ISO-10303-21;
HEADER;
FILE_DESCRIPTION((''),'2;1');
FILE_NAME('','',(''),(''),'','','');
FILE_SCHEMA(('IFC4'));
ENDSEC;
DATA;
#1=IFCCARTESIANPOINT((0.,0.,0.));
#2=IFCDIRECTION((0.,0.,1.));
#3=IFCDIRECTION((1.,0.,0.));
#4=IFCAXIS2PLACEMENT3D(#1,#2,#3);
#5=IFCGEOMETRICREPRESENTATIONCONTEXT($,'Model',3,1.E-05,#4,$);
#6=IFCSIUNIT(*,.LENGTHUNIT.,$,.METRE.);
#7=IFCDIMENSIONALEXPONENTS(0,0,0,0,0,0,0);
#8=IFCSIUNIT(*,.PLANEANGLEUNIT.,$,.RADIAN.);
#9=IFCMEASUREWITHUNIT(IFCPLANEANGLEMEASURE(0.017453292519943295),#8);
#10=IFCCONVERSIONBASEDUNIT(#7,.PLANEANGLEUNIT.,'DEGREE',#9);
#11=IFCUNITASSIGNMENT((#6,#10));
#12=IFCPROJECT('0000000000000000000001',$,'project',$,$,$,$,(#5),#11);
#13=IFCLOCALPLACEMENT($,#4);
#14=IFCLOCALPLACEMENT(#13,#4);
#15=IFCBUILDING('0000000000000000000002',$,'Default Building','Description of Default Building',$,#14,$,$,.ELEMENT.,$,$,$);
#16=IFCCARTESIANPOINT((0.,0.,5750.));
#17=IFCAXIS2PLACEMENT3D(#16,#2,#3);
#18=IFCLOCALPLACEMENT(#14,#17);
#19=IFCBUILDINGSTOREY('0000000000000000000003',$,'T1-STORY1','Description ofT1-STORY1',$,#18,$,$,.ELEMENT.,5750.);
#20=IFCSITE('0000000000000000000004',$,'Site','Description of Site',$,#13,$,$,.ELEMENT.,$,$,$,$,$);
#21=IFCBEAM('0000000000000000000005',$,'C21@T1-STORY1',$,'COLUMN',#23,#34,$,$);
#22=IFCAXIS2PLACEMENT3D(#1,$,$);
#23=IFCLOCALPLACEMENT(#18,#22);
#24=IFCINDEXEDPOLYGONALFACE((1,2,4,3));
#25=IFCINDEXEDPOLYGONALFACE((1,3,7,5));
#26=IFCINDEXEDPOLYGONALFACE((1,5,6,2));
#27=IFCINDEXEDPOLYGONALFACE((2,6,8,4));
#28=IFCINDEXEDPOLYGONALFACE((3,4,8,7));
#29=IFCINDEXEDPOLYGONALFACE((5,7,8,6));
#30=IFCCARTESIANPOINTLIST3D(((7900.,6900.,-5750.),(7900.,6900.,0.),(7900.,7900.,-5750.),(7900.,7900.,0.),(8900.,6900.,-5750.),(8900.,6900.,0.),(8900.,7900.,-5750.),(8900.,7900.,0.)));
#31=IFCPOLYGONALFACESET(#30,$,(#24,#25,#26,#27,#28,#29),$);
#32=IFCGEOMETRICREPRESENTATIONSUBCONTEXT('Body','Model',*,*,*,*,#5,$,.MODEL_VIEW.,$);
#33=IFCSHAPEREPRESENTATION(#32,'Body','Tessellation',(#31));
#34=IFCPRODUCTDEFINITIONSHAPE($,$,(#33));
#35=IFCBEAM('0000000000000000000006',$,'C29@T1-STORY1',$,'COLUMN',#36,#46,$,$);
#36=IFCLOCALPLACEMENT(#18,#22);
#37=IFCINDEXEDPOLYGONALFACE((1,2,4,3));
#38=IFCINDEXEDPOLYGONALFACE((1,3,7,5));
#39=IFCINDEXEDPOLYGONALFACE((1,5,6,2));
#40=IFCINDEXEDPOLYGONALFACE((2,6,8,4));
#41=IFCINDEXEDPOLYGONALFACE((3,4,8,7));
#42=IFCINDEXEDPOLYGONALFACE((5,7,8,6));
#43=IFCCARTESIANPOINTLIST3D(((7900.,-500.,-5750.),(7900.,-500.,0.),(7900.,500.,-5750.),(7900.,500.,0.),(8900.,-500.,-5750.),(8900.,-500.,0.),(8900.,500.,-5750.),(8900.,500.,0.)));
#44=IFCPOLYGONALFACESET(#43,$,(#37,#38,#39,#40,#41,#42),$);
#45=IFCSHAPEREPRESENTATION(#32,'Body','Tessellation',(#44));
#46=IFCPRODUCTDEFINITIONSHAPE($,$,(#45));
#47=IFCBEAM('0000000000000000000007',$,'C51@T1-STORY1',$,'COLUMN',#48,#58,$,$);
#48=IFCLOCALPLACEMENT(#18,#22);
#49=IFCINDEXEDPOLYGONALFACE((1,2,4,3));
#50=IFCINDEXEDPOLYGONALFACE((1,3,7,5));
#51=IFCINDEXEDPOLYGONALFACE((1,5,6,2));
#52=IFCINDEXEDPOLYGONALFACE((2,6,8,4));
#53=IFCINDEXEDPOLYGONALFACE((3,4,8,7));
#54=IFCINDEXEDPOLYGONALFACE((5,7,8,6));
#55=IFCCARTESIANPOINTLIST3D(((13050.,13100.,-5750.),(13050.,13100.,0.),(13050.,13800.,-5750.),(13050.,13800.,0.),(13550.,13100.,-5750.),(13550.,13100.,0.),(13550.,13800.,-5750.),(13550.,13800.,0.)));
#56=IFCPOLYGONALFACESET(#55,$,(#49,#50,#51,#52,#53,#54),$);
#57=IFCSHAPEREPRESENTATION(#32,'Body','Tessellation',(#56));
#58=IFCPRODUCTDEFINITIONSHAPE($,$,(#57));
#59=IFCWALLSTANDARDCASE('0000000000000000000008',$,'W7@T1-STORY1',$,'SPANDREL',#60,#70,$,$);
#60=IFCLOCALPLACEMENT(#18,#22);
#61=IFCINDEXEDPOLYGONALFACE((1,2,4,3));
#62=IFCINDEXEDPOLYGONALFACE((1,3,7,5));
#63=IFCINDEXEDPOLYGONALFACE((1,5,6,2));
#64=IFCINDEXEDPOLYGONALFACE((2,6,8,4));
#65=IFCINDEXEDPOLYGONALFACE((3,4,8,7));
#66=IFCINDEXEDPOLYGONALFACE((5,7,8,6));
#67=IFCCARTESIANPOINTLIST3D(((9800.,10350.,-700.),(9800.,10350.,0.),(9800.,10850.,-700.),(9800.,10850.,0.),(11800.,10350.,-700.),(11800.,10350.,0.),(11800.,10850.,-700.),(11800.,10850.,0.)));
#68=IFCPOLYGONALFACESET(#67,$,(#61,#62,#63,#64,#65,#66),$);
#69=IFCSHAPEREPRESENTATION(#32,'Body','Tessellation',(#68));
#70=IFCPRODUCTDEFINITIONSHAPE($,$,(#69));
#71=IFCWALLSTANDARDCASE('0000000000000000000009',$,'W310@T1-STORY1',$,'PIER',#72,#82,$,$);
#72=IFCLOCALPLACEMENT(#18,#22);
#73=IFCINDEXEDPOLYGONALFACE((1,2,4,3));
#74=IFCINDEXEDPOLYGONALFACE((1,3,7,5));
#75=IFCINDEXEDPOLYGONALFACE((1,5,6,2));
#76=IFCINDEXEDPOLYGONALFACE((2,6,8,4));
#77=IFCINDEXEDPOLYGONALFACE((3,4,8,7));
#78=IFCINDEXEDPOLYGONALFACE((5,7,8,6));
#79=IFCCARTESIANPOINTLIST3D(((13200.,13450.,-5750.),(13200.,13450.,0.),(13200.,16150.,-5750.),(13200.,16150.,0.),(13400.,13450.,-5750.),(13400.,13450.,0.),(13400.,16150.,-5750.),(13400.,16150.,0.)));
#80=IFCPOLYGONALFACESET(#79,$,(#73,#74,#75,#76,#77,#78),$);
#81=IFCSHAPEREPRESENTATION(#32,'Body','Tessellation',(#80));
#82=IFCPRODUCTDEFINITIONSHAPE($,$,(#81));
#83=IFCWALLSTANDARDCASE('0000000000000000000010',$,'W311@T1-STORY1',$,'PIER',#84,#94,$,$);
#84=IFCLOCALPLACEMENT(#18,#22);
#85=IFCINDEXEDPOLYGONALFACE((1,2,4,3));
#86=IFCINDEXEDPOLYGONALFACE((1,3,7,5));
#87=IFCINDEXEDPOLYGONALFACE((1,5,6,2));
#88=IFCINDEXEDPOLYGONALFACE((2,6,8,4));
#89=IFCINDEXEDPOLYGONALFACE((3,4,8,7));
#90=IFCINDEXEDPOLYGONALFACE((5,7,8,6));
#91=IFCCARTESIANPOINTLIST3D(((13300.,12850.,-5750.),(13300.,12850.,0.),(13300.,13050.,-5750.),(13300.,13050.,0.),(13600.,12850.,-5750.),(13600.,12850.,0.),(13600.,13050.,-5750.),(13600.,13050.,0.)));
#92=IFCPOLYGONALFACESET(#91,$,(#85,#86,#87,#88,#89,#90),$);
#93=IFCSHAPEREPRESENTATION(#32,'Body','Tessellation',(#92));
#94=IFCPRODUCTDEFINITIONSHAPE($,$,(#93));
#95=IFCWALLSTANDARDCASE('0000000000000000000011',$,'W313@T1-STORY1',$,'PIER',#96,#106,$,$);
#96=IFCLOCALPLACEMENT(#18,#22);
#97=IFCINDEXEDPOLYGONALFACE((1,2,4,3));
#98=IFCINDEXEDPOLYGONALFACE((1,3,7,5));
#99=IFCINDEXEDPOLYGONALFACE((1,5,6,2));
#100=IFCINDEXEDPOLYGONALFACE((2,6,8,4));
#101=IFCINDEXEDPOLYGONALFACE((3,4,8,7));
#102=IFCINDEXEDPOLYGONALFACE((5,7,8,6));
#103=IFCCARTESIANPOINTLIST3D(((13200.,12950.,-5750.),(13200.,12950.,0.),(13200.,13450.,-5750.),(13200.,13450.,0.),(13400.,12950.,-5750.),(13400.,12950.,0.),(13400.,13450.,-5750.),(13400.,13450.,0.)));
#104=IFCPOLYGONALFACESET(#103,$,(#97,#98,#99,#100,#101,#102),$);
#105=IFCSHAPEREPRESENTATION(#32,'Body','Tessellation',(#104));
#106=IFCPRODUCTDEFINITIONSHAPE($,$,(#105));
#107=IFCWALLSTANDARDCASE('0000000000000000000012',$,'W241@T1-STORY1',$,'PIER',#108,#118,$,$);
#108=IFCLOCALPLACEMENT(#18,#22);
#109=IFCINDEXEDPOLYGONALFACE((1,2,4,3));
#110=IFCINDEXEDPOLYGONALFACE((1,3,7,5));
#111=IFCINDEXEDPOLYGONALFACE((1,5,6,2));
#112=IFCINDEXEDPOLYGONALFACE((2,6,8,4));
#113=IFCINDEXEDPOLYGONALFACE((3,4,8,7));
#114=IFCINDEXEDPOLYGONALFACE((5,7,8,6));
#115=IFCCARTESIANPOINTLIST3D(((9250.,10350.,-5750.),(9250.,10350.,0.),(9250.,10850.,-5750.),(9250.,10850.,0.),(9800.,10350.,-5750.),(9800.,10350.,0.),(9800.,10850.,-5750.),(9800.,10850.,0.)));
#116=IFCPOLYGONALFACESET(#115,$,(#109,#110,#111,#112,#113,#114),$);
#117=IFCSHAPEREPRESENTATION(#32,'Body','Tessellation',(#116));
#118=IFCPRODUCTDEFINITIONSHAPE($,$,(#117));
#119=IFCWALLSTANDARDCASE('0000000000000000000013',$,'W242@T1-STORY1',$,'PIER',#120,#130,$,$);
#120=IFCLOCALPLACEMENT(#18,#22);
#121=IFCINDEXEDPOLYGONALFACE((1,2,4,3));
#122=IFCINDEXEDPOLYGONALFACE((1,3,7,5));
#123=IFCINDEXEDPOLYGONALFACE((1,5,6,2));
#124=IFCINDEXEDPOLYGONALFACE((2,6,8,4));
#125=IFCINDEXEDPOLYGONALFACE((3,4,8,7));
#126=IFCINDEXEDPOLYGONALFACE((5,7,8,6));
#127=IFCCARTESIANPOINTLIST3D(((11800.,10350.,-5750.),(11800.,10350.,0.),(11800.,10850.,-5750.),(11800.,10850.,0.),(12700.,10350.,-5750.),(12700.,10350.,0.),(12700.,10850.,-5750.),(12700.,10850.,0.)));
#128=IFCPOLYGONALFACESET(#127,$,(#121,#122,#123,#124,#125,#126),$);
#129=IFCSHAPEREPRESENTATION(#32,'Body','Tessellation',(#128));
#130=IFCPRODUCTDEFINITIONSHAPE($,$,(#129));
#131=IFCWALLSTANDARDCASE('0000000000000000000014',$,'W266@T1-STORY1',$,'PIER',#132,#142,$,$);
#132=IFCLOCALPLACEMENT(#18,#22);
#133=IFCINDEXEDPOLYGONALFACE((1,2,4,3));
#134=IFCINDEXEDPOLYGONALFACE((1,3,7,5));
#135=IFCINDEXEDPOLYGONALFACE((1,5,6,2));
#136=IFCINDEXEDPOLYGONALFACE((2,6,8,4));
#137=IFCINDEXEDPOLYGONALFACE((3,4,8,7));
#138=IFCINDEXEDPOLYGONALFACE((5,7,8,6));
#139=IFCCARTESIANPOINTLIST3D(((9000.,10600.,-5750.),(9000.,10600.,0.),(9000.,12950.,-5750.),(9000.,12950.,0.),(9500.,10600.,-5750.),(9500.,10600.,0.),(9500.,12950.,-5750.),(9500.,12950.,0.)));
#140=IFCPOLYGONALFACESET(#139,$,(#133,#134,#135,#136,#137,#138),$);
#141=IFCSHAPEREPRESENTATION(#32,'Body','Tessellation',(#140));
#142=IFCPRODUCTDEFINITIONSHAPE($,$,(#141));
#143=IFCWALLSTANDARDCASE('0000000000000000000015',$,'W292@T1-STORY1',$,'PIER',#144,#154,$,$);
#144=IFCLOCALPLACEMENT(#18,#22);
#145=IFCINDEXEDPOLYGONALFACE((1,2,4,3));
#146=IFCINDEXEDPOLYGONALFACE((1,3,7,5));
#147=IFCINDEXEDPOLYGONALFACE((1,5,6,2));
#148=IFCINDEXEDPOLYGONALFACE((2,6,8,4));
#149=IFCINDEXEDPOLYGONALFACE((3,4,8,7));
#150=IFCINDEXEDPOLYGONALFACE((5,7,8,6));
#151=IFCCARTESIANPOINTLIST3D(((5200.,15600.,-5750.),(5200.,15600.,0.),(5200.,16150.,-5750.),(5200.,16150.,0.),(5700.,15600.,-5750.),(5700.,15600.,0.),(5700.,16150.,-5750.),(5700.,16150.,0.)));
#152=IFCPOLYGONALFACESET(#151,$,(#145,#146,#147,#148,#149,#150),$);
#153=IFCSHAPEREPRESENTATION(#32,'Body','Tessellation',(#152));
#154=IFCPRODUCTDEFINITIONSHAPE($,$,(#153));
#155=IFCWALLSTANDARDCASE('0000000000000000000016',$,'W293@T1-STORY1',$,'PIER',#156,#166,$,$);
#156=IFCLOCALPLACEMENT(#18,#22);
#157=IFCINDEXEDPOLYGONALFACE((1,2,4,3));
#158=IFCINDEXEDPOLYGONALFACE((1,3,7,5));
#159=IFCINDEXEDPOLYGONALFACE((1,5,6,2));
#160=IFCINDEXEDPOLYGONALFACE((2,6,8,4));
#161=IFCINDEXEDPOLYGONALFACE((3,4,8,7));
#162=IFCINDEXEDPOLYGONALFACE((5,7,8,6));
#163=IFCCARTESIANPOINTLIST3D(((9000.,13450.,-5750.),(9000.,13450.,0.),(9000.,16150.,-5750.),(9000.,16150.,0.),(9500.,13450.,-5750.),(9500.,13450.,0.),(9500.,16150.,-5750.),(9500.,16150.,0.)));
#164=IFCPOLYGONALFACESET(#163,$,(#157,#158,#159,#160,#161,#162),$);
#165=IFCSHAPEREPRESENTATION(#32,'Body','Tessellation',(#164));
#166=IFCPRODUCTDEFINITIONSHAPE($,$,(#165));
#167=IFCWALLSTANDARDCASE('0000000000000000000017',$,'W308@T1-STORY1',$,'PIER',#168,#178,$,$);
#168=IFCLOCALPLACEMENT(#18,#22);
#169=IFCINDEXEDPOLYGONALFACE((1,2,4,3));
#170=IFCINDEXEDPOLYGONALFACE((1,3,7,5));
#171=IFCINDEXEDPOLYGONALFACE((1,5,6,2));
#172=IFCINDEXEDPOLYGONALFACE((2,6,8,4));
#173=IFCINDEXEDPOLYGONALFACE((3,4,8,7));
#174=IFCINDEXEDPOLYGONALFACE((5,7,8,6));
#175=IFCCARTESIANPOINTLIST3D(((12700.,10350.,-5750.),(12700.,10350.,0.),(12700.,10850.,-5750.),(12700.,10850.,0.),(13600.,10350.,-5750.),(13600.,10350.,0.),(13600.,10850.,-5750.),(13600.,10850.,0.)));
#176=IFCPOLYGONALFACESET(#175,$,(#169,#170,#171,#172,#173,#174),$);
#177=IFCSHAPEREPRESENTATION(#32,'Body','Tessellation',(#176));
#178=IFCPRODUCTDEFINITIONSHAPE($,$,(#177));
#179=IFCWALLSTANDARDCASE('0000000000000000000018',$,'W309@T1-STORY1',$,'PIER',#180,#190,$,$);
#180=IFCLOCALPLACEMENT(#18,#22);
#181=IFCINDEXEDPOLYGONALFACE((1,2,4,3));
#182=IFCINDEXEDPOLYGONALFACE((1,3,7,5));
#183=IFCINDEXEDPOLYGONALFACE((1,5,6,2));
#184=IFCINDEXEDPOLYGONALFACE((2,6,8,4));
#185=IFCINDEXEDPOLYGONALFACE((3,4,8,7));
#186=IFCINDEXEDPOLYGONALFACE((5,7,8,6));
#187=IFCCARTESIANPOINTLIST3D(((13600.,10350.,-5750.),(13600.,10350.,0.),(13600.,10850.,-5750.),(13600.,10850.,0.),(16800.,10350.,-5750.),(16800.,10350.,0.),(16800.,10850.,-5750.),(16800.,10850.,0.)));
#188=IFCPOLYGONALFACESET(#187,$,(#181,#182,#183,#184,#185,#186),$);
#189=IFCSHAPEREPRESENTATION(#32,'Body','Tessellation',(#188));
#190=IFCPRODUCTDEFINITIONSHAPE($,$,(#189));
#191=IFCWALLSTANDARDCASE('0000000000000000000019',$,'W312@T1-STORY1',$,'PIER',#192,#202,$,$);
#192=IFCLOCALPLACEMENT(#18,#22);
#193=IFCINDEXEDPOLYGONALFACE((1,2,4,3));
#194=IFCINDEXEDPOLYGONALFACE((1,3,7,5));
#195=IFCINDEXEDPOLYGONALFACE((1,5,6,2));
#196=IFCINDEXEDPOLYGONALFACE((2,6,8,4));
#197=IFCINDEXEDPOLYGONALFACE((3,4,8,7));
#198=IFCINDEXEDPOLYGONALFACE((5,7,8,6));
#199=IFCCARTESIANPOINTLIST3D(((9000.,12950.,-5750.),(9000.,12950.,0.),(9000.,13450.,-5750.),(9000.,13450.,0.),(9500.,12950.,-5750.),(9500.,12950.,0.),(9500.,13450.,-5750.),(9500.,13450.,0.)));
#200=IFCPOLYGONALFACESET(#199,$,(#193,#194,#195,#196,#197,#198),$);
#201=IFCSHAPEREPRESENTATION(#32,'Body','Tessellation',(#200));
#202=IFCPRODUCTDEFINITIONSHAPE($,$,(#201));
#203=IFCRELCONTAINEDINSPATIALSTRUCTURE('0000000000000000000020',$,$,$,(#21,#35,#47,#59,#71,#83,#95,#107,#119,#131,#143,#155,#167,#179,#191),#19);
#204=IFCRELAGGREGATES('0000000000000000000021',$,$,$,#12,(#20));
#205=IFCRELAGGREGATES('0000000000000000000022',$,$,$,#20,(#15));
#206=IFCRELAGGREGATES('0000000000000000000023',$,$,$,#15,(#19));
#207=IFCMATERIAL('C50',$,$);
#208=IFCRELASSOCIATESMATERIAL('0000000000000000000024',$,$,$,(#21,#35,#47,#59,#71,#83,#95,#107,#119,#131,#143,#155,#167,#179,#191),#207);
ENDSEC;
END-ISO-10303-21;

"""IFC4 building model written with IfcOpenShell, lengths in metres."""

from ifc_helpers import new_model, entity, si_unit, converted_unit, frame, origin_with_axes, place, context, subcontext, project, spatial, indexed_curve, rectangle, outline, extrude, material, element, save


model = new_model("IFC4")

# Units and contexts
model_context = context("Model", 3, precision=1e-05, world=origin_with_axes())
body_context = subcontext(model_context, "Body", "Model", "MODEL_VIEW")
ifc_project = project(units=[si_unit("LENGTHUNIT", "METRE"), converted_unit("PLANEANGLEUNIT", "DEGREE", entity("IfcPlaneAngleMeasure", 0.017453292519943295), si_unit("PLANEANGLEUNIT", "RADIAN"), dimensions=[0, 0, 0, 0, 0, 0, 0])], contexts=[model_context])

# Site, building, storey
site_placement = place(None, origin_with_axes())
site = spatial("IfcSite", under=ifc_project, at=site_placement, Name="Site", Description="Description of Site", CompositionType="ELEMENT")
building_placement = place(site_placement, origin_with_axes())
building = spatial("IfcBuilding", under=site, at=building_placement, Name="Default Building", Description="Description of Default Building", CompositionType="ELEMENT")
storey_placement = place(building_placement, frame((0.0, 0.0, 5750.0), z_axis=(0.0, 0.0, 1.0), x_axis=(1.0, 0.0, 0.0)))
storey = spatial("IfcBuildingStorey", under=building, at=storey_placement, Name="T1-STORY1", Description="Description ofT1-STORY1", CompositionType="ELEMENT", Elevation=5750.0)

# Beams
ifc_material_1 = material(Name="C50")
for number, where, z_axis, x_axis, name in (
    (1, (8400.0, 7400.0, -5750.0), (0.0, 0.0, 1.0), (-1.0, 0.0, 0.0), "C21@T1-STORY1"),
    (2, (8400.0, 0.0, -5750.0), (0.0, 0.0, 1.0), (-1.0, 0.0, 0.0), "C29@T1-STORY1"),
):
    element("IfcBeam", number, at=place(storey_placement, frame(where, z_axis=z_axis, x_axis=x_axis)), inside=storey, material=ifc_material_1, Name=name, ObjectType="COLUMN", context=body_context, shape_type="SweptSolid", body=[
        extrude(rectangle(XDim=1000.0, YDim=1000.0), origin_with_axes(), (0.0, 0.0, 1.0), 5750.0),
    ])
beam_1_placement = place(storey_placement, frame((13300.0, 13450.0, -5750.0), z_axis=(0.0, 0.0, 1.0), x_axis=(-1.0, 0.0, 0.0)))
element("IfcBeam", 3, at=beam_1_placement, inside=storey, material=ifc_material_1, Name="C51@T1-STORY1", ObjectType="COLUMN", context=body_context, shape_type="SweptSolid", body=[
    extrude(rectangle(XDim=500.0, YDim=700.0), origin_with_axes(), (0.0, 0.0, 1.0), 5750.0),
])

# Walls
wall_1_placement = place(storey_placement, frame((9800.0, 10600.0, -700.0), z_axis=(0.0, 0.0, 1.0), x_axis=(1.0, 0.0, 0.0)))
element("IfcWallStandardCase", 4, at=wall_1_placement, inside=storey, material=ifc_material_1, Name="W7@T1-STORY1", ObjectType="SPANDREL", context=body_context, shape_type="SweptSolid", body=[
    extrude(outline(indexed_curve([(0.0, -250.0), (0.0, 250.0), (2000.0, 250.0), (2000.0, -250.0), (0.0, -250.0)], self_intersect=False)), origin_with_axes(), (0.0, 0.0, 1.0), 700.0),
])
wall_2_placement = place(storey_placement, frame((13300.0, 13450.0, -5750.0), z_axis=(0.0, 0.0, 1.0), x_axis=(0.0, 1.0, 0.0)))
element("IfcWallStandardCase", 5, at=wall_2_placement, inside=storey, material=ifc_material_1, Name="W310@T1-STORY1", ObjectType="PIER", context=body_context, shape_type="SweptSolid", body=[
    extrude(outline(indexed_curve([(0.0, -100.0), (0.0, 100.0), (2700.0, 100.0), (2700.0, -100.0), (0.0, -100.0)], self_intersect=False)), origin_with_axes(), (0.0, 0.0, 1.0), 5750.0),
])
wall_3_placement = place(storey_placement, frame((13300.0, 12950.0, -5750.0), z_axis=(0.0, 0.0, 1.0), x_axis=(1.0, 0.0, 0.0)))
element("IfcWallStandardCase", 6, at=wall_3_placement, inside=storey, material=ifc_material_1, Name="W311@T1-STORY1", ObjectType="PIER", context=body_context, shape_type="SweptSolid", body=[
    extrude(outline(indexed_curve([(0.0, -100.0), (0.0, 100.0), (300.0, 100.0), (300.0, -100.0), (0.0, -100.0)], self_intersect=False)), origin_with_axes(), (0.0, 0.0, 1.0), 5750.0),
])
wall_4_placement = place(storey_placement, frame((13300.0, 12950.0, -5750.0), z_axis=(0.0, 0.0, 1.0), x_axis=(0.0, 1.0, 0.0)))
element("IfcWallStandardCase", 7, at=wall_4_placement, inside=storey, material=ifc_material_1, Name="W313@T1-STORY1", ObjectType="PIER", context=body_context, shape_type="SweptSolid", body=[
    extrude(outline(indexed_curve([(0.0, -100.0), (0.0, 100.0), (500.0, 100.0), (500.0, -100.0), (0.0, -100.0)], self_intersect=False)), origin_with_axes(), (0.0, 0.0, 1.0), 5750.0),
])
wall_5_placement = place(storey_placement, frame((9250.0, 10600.0, -5750.0), z_axis=(0.0, 0.0, 1.0), x_axis=(1.0, 0.0, 0.0)))
element("IfcWallStandardCase", 8, at=wall_5_placement, inside=storey, material=ifc_material_1, Name="W241@T1-STORY1", ObjectType="PIER", context=body_context, shape_type="SweptSolid", body=[
    extrude(outline(indexed_curve([(0.0, -250.0), (0.0, 250.0), (550.0, 250.0), (550.0, -250.0), (0.0, -250.0)], self_intersect=False)), origin_with_axes(), (0.0, 0.0, 1.0), 5750.0),
])
wall_6_placement = place(storey_placement, frame((11800.0, 10600.0, -5750.0), z_axis=(0.0, 0.0, 1.0), x_axis=(1.0, 0.0, 0.0)))
element("IfcWallStandardCase", 9, at=wall_6_placement, inside=storey, material=ifc_material_1, Name="W242@T1-STORY1", ObjectType="PIER", context=body_context, shape_type="SweptSolid", body=[
    extrude(outline(indexed_curve([(0.0, -250.0), (0.0, 250.0), (900.0, 250.0), (900.0, -250.0), (0.0, -250.0)], self_intersect=False)), origin_with_axes(), (0.0, 0.0, 1.0), 5750.0),
])
wall_7_placement = place(storey_placement, frame((9250.0, 10600.0, -5750.0), z_axis=(0.0, 0.0, 1.0), x_axis=(0.0, 1.0, 0.0)))
element("IfcWallStandardCase", 10, at=wall_7_placement, inside=storey, material=ifc_material_1, Name="W266@T1-STORY1", ObjectType="PIER", context=body_context, shape_type="SweptSolid", body=[
    extrude(outline(indexed_curve([(0.0, -250.0), (0.0, 250.0), (2350.0, 250.0), (2350.0, -250.0), (0.0, -250.0)], self_intersect=False)), origin_with_axes(), (0.0, 0.0, 1.0), 5750.0),
])
wall_8_placement = place(storey_placement, frame((5450.0, 15600.0, -5750.0), z_axis=(0.0, 0.0, 1.0), x_axis=(0.0, 1.0, 0.0)))
element("IfcWallStandardCase", 11, at=wall_8_placement, inside=storey, material=ifc_material_1, Name="W292@T1-STORY1", ObjectType="PIER", context=body_context, shape_type="SweptSolid", body=[
    extrude(outline(indexed_curve([(0.0, -250.0), (0.0, 250.0), (550.0, 250.0), (550.0, -250.0), (0.0, -250.0)], self_intersect=False)), origin_with_axes(), (0.0, 0.0, 1.0), 5750.0),
])
wall_9_placement = place(storey_placement, frame((9250.0, 13450.0, -5750.0), z_axis=(0.0, 0.0, 1.0), x_axis=(0.0, 1.0, 0.0)))
element("IfcWallStandardCase", 12, at=wall_9_placement, inside=storey, material=ifc_material_1, Name="W293@T1-STORY1", ObjectType="PIER", context=body_context, shape_type="SweptSolid", body=[
    extrude(outline(indexed_curve([(0.0, -250.0), (0.0, 250.0), (2700.0, 250.0), (2700.0, -250.0), (0.0, -250.0)], self_intersect=False)), origin_with_axes(), (0.0, 0.0, 1.0), 5750.0),
])
wall_10_placement = place(storey_placement, frame((12700.0, 10600.0, -5750.0), z_axis=(0.0, 0.0, 1.0), x_axis=(1.0, 0.0, 0.0)))
element("IfcWallStandardCase", 13, at=wall_10_placement, inside=storey, material=ifc_material_1, Name="W308@T1-STORY1", ObjectType="PIER", context=body_context, shape_type="SweptSolid", body=[
    extrude(outline(indexed_curve([(0.0, -250.0), (0.0, 250.0), (900.0, 250.0), (900.0, -250.0), (0.0, -250.0)], self_intersect=False)), origin_with_axes(), (0.0, 0.0, 1.0), 5750.0),
])
wall_11_placement = place(storey_placement, frame((13600.0, 10600.0, -5750.0), z_axis=(0.0, 0.0, 1.0), x_axis=(1.0, 0.0, 0.0)))
element("IfcWallStandardCase", 14, at=wall_11_placement, inside=storey, material=ifc_material_1, Name="W309@T1-STORY1", ObjectType="PIER", context=body_context, shape_type="SweptSolid", body=[
    extrude(outline(indexed_curve([(0.0, -250.0), (0.0, 250.0), (3200.0, 250.0), (3200.0, -250.0), (0.0, -250.0)], self_intersect=False)), origin_with_axes(), (0.0, 0.0, 1.0), 5750.0),
])
wall_12_placement = place(storey_placement, frame((9250.0, 12950.0, -5750.0), z_axis=(0.0, 0.0, 1.0), x_axis=(0.0, 1.0, 0.0)))
element("IfcWallStandardCase", 15, at=wall_12_placement, inside=storey, material=ifc_material_1, Name="W312@T1-STORY1", ObjectType="PIER", context=body_context, shape_type="SweptSolid", body=[
    extrude(outline(indexed_curve([(0.0, -250.0), (0.0, 250.0), (500.0, 250.0), (500.0, -250.0), (0.0, -250.0)], self_intersect=False)), origin_with_axes(), (0.0, 0.0, 1.0), 5750.0),
])

save(model, "model.ifc")
